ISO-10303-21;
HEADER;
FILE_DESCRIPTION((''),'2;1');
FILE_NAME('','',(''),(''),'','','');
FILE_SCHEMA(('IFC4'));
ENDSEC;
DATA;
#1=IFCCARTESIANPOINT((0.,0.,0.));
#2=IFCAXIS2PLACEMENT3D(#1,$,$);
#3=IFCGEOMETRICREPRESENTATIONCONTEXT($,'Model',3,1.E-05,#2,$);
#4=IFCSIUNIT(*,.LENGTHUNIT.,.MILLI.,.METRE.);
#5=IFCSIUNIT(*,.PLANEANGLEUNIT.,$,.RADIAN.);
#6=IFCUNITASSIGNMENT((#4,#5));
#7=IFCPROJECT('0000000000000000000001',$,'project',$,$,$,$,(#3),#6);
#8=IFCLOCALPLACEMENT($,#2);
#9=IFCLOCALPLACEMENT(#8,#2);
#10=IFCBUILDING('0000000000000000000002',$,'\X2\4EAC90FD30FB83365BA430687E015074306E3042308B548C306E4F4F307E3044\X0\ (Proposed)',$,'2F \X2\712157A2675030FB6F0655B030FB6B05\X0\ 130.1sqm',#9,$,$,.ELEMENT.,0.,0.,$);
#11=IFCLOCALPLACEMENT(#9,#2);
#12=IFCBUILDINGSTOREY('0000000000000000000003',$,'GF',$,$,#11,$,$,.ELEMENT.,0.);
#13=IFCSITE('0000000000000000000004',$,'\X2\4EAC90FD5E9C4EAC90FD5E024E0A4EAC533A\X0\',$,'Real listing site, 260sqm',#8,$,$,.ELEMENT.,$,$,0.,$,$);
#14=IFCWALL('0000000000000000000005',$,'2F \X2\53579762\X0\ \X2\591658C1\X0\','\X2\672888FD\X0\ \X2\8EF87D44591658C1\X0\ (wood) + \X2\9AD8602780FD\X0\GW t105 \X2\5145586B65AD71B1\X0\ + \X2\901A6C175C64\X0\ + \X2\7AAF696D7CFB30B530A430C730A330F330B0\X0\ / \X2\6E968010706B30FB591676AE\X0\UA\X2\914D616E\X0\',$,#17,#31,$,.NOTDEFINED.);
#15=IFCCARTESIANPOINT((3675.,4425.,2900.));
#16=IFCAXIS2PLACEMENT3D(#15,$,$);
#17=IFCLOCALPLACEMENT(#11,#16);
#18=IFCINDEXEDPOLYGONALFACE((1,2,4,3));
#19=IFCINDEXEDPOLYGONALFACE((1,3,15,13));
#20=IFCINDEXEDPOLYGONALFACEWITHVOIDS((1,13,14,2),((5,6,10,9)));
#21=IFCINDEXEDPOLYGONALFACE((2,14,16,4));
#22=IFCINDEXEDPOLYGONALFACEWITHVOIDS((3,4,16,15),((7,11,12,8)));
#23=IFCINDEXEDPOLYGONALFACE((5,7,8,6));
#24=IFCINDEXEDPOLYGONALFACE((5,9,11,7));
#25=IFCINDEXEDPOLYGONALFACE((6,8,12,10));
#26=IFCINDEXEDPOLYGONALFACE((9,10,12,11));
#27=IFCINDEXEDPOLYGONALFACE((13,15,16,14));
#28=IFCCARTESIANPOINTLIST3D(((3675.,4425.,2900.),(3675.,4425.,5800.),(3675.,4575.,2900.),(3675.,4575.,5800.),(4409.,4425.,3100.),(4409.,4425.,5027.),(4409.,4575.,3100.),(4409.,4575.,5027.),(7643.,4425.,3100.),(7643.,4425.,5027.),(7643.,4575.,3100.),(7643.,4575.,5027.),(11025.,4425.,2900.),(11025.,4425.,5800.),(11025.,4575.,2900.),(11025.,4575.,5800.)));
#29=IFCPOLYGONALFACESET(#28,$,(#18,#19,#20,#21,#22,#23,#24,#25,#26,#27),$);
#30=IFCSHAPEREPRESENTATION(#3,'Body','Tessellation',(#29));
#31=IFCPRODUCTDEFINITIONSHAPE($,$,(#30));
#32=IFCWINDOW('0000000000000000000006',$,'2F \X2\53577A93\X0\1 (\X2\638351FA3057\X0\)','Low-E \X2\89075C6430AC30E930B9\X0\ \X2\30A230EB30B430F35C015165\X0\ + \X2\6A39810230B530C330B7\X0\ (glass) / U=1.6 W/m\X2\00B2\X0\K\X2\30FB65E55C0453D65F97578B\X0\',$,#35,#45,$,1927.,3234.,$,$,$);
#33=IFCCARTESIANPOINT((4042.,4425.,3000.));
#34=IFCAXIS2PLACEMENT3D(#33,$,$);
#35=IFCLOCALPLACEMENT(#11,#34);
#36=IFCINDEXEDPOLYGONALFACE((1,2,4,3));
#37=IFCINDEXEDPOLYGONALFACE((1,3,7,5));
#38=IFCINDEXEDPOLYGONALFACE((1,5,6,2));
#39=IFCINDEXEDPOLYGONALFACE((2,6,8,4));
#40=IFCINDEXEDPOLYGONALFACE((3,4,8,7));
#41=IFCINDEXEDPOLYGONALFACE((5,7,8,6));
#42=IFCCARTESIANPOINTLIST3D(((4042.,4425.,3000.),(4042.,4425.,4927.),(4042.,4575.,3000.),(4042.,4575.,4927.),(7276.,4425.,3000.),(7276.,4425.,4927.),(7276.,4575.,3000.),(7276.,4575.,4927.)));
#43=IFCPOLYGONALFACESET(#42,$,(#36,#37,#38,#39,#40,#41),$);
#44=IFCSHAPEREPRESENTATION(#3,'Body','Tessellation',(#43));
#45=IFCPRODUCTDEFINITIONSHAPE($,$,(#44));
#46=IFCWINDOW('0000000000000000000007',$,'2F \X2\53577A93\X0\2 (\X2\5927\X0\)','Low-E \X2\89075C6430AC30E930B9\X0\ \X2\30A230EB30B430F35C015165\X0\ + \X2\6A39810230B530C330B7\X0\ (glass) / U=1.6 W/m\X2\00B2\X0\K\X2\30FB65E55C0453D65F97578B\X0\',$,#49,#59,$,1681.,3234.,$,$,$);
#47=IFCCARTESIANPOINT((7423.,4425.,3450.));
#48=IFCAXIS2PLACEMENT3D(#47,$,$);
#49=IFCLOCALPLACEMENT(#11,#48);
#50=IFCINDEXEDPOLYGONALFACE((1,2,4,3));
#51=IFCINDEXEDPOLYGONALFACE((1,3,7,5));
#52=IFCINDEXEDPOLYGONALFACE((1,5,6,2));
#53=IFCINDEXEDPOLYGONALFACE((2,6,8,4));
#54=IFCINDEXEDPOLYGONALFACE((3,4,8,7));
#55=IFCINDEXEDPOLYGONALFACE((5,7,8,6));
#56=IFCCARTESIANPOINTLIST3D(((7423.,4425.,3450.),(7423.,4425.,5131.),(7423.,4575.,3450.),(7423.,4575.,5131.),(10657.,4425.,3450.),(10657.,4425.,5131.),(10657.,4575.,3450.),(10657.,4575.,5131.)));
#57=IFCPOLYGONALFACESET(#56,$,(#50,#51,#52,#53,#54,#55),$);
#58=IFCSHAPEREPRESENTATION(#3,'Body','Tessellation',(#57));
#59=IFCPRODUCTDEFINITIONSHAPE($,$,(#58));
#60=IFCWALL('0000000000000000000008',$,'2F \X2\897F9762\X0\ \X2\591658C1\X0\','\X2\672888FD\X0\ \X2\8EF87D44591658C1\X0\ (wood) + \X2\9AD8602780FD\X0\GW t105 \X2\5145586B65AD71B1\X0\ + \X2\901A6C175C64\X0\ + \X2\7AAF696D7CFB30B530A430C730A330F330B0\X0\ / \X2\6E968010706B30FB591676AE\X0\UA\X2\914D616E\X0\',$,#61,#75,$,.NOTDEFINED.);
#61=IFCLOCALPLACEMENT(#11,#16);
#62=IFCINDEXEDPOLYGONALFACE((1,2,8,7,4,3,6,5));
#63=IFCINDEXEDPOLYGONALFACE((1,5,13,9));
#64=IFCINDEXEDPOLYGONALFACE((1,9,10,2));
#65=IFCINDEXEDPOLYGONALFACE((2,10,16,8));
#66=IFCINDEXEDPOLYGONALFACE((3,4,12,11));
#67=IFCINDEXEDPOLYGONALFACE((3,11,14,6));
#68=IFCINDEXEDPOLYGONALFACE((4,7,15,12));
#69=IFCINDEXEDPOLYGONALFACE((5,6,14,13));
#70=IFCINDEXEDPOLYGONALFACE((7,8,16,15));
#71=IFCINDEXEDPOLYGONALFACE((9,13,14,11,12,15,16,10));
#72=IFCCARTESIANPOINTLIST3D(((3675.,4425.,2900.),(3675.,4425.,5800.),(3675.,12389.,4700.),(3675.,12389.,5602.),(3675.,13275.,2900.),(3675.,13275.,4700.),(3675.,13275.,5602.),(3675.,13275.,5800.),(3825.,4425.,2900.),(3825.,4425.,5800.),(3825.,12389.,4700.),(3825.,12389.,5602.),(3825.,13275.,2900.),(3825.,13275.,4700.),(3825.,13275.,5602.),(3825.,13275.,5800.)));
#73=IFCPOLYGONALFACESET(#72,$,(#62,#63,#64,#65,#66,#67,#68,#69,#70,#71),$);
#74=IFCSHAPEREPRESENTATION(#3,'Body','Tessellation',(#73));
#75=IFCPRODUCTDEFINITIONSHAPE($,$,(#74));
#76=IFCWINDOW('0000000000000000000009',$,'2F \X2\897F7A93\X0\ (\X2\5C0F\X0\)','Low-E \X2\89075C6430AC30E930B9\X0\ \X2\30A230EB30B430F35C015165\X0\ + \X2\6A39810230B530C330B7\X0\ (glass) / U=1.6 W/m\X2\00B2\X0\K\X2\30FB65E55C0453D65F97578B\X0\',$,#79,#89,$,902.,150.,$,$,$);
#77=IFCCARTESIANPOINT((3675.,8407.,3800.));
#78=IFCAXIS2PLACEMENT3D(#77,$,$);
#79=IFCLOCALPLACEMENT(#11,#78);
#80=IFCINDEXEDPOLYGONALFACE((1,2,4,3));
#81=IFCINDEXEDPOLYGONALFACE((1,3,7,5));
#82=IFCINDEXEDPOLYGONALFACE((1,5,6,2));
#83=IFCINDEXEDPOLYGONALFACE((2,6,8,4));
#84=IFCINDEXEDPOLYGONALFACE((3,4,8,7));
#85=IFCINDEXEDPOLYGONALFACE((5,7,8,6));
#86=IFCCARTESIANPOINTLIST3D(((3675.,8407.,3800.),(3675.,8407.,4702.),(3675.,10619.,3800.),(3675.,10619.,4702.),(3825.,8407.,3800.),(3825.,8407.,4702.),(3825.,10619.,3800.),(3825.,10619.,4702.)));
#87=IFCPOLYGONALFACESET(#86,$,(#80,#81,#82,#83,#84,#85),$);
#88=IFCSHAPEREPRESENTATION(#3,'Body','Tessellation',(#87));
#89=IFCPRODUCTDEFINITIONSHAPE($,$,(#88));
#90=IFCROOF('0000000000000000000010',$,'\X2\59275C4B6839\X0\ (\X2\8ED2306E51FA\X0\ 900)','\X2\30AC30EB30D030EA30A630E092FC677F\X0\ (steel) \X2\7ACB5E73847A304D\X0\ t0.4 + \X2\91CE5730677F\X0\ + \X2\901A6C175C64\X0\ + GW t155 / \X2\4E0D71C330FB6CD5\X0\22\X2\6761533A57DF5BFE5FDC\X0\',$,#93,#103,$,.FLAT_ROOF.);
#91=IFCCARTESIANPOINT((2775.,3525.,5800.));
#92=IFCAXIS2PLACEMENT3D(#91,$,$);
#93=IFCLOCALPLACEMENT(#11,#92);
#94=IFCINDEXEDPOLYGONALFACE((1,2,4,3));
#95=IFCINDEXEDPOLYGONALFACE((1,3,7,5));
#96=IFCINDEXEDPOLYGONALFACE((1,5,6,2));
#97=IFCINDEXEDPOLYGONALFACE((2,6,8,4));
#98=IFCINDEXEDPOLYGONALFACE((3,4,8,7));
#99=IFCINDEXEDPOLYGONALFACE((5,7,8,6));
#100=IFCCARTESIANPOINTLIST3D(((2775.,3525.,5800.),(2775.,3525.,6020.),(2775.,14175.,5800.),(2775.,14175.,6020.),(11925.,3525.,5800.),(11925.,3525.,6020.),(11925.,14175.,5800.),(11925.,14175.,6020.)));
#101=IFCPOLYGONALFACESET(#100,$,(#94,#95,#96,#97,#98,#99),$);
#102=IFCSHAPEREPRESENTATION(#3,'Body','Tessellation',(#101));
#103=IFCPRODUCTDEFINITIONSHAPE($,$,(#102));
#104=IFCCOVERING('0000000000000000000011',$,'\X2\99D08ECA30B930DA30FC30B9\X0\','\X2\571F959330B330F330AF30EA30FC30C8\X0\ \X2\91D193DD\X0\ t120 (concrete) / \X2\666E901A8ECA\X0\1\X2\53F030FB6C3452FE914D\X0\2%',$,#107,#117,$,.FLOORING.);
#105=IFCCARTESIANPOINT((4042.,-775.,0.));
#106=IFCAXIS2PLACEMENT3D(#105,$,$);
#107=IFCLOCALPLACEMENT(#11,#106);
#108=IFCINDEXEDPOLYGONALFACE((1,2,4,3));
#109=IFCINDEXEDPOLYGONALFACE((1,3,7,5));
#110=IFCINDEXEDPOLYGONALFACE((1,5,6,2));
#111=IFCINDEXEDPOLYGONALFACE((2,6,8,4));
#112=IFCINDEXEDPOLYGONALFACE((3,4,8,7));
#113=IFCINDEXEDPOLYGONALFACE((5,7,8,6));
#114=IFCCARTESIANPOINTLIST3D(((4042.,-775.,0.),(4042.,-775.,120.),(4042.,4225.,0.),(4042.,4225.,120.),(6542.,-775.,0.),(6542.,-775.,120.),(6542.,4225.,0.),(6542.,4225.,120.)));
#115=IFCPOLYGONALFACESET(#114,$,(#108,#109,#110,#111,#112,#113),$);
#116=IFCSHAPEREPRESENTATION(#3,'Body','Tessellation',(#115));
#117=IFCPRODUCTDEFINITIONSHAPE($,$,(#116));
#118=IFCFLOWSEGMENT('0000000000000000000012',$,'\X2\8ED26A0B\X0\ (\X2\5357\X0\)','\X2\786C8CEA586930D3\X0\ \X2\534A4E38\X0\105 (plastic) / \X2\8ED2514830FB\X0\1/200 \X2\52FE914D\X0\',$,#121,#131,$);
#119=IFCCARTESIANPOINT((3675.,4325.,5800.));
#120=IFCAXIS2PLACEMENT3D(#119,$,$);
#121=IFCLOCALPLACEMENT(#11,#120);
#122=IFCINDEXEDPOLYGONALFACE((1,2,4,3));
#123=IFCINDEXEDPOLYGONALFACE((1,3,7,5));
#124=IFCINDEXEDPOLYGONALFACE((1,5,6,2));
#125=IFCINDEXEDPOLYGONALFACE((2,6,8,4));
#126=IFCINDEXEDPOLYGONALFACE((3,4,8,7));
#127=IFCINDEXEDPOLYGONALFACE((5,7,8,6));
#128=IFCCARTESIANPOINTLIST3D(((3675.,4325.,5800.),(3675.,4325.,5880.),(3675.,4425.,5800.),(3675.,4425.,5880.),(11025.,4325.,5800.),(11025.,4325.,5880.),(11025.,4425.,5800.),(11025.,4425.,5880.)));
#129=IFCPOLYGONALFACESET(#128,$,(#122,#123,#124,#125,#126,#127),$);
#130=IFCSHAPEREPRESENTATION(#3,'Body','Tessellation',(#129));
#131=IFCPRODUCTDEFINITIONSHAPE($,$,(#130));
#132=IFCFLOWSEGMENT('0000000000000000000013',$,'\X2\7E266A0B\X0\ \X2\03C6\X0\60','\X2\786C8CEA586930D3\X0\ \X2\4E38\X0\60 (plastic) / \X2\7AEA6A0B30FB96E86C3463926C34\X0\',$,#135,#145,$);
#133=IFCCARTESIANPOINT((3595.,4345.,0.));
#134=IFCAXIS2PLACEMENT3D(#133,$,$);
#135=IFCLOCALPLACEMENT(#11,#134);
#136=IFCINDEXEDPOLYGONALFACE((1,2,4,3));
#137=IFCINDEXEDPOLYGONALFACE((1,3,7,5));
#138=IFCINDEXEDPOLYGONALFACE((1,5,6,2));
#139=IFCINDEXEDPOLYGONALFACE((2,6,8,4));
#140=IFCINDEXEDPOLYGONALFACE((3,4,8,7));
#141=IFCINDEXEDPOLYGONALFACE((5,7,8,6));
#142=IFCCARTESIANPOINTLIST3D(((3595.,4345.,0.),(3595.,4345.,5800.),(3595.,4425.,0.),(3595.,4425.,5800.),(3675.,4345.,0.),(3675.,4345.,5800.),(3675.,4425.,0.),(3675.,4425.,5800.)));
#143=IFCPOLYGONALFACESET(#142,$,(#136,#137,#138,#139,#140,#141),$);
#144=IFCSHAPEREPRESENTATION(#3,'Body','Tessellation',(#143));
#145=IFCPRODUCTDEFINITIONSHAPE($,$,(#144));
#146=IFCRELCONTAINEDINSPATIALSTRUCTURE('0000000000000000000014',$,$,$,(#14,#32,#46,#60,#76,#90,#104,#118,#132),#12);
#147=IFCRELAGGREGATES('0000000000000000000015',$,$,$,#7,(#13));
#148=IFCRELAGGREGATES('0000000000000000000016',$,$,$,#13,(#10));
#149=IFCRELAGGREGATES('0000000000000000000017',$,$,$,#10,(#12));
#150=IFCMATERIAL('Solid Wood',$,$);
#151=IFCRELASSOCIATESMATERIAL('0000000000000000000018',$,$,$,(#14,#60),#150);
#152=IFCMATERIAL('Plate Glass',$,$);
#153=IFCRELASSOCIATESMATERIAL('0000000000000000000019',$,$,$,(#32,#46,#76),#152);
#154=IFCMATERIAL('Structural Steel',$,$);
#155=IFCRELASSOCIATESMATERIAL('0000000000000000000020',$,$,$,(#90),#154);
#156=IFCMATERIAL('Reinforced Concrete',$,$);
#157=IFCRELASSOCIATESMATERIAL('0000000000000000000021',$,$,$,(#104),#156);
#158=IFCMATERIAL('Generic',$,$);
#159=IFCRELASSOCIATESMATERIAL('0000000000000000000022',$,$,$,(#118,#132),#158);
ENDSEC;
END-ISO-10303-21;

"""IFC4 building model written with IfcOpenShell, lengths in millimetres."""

from ifc_helpers import new_model, si_unit, frame, frame_2d, origin, place, context, project, spatial, rectangle, extrude, material, element, fill, save


model = new_model("IFC4")

# Units and contexts
model_context = context("Model", 3, precision=1e-05, world=origin())
ifc_project = project(units=[si_unit("LENGTHUNIT", "METRE", prefix="MILLI"), si_unit("PLANEANGLEUNIT", "RADIAN")], contexts=[model_context])

# Site, building, storey
site_placement = place(None, origin())
site = spatial("IfcSite", under=ifc_project, at=site_placement, Name="京都府京都市上京区", ObjectType="Real listing site, 260sqm", CompositionType="ELEMENT", RefElevation=0.0)
building_placement = place(site_placement, origin())
building = spatial("IfcBuilding", under=site, at=building_placement, Name="京都・茶室と縁側のある和の住まい (Proposed)", ObjectType="2F 無垢材・漆喰・欅 130.1sqm", CompositionType="ELEMENT", ElevationOfRefHeight=0.0, ElevationOfTerrain=0.0)
storey_placement = place(building_placement, origin())
storey = spatial("IfcBuildingStorey", under=building, at=storey_placement, Name="GF", CompositionType="ELEMENT", Elevation=0.0)

# Shared definitions
ifc_material_1 = material(Name="Solid Wood")

# Shared definitions
ifc_material_2 = material(Name="Reinforced Concrete")

# Shared definitions
ifc_material_3 = material(Name="Plate Glass")

# Wall, openings, windows
wall_1_placement = place(storey_placement, frame((3675.0, 4425.0, 2900.0)))
wall_1 = element("IfcWall", 1, at=wall_1_placement, inside=storey, material=ifc_material_1, Name="2F 南面 外壁", Description="木製 軸組外壁 (wood) + 高性能GW t105 充填断熱 + 通気層 + 窯業系サイディング / 準耐火・外皮UA配慮", PredefinedType="NOTDEFINED", context=model_context, shape_type="SweptSolid", body=[
    extrude(rectangle(XDim=7350.0, YDim=150.0, at=frame_2d((3675.0, 75.0))), frame((3675.0, 4425.0, 2900.0)), (0.0, 0.0, 1.0), 2900.0),
])
opening_1_placement = place(storey_placement, frame((4042.0, 4425.0, 3000.0)))
opening_1 = element("IfcOpeningElement", 2, at=opening_1_placement, cuts=wall_1, PredefinedType="NOTDEFINED", context=model_context, shape_type="SweptSolid", body=[
    extrude(rectangle(XDim=3234.0, YDim=150.0, at=frame_2d((1617.0, 75.0))), frame((4042.0, 4425.0, 3000.0)), (0.0, 0.0, 1.0), 1927.0),
])
opening_2_placement = place(storey_placement, frame((7423.0, 4425.0, 3450.0)))
opening_2 = element("IfcOpeningElement", 3, at=opening_2_placement, cuts=wall_1, PredefinedType="NOTDEFINED", context=model_context, shape_type="SweptSolid", body=[
    extrude(rectangle(XDim=3234.0, YDim=150.0, at=frame_2d((1617.0, 75.0))), frame((7423.0, 4425.0, 3450.0)), (0.0, 0.0, 1.0), 1681.0),
])
window_1_placement = place(storey_placement, frame((4042.0, 4425.0, 3000.0)))
window_1 = element("IfcWindow", 4, at=window_1_placement, inside=storey, material=ifc_material_3, Name="2F 南窓1 (掃出し)", Description="Low-E 複層ガラス アルゴン封入 + 樹脂サッシ (glass) / U=1.6 W/m²K・日射取得型", OverallHeight=1927.0, OverallWidth=3234.0, context=model_context, shape_type="SweptSolid", body=[
    extrude(rectangle(XDim=3234.0, YDim=150.0, at=frame_2d((1617.0, 75.0))), frame((4042.0, 4425.0, 3000.0)), (0.0, 0.0, 1.0), 1927.0),
])
fill(opening_1, window_1)
window_2_placement = place(storey_placement, frame((7423.0, 4425.0, 3450.0)))
window_2 = element("IfcWindow", 5, at=window_2_placement, inside=storey, material=ifc_material_3, Name="2F 南窓2 (大)", Description="Low-E 複層ガラス アルゴン封入 + 樹脂サッシ (glass) / U=1.6 W/m²K・日射取得型", OverallHeight=1681.0, OverallWidth=3234.0, context=model_context, shape_type="SweptSolid", body=[
    extrude(rectangle(XDim=3234.0, YDim=150.0, at=frame_2d((1617.0, 75.0))), frame((7423.0, 4425.0, 3450.0)), (0.0, 0.0, 1.0), 1681.0),
])
fill(opening_2, window_2)

# Wall, opening, window
wall_2_placement = place(storey_placement, frame((3675.0, 4425.0, 2900.0)))
wall_2 = element("IfcWall", 6, at=wall_2_placement, inside=storey, material=ifc_material_1, Name="2F 西面 外壁", Description="木製 軸組外壁 (wood) + 高性能GW t105 充填断熱 + 通気層 + 窯業系サイディング / 準耐火・外皮UA配慮", PredefinedType="NOTDEFINED", context=model_context, shape_type="SweptSolid", body=[
    extrude(rectangle(XDim=150.0, YDim=8850.0, at=frame_2d((75.0, 4425.0))), frame((3675.0, 4425.0, 2900.0)), (0.0, 0.0, 1.0), 2900.0),
])
opening_3_placement = place(storey_placement, frame((3675.0, 8407.0, 3800.0)))
opening_3 = element("IfcOpeningElement", 7, at=opening_3_placement, cuts=wall_2, PredefinedType="NOTDEFINED", context=model_context, shape_type="SweptSolid", body=[
    extrude(rectangle(XDim=150.0, YDim=2212.0, at=frame_2d((75.0, 1106.0))), frame((3675.0, 8407.0, 3800.0)), (0.0, 0.0, 1.0), 902.0),
])
window_3_placement = place(storey_placement, frame((3675.0, 8407.0, 3800.0)))
window_3 = element("IfcWindow", 8, at=window_3_placement, inside=storey, material=ifc_material_3, Name="2F 西窓 (小)", Description="Low-E 複層ガラス アルゴン封入 + 樹脂サッシ (glass) / U=1.6 W/m²K・日射取得型", OverallHeight=902.0, OverallWidth=150.0, context=model_context, shape_type="SweptSolid", body=[
    extrude(rectangle(XDim=150.0, YDim=2212.0, at=frame_2d((75.0, 1106.0))), frame((3675.0, 8407.0, 3800.0)), (0.0, 0.0, 1.0), 902.0),
])
fill(opening_3, window_3)

# Roof
ifc_material_4 = material(Name="Structural Steel")
roof_placement = place(storey_placement, frame((2775.0, 3525.0, 5800.0)))
element("IfcRoof", 9, at=roof_placement, inside=storey, material=ifc_material_4, Name="大屋根 (軒の出 900)", Description="ガルバリウム鋼板 (steel) 立平葺き t0.4 + 野地板 + 通気層 + GW t155 / 不燃・法22条区域対応", PredefinedType="FLAT_ROOF", context=model_context, shape_type="SweptSolid", body=[
    extrude(rectangle(XDim=9150.0, YDim=10650.0, at=frame_2d((4575.0, 5325.0))), frame((2775.0, 3525.0, 5800.0)), (0.0, 0.0, 1.0), 220.0),
])

# Covering
covering_placement = place(storey_placement, frame((4042.0, -775.0, 0.0)))
element("IfcCovering", 10, at=covering_placement, inside=storey, material=ifc_material_2, Name="駐車スペース", Description="土間コンクリート 金鏝 t120 (concrete) / 普通車1台・水勾配2%", PredefinedType="FLOORING", context=model_context, shape_type="SweptSolid", body=[
    extrude(rectangle(XDim=2500.0, YDim=5000.0, at=frame_2d((1250.0, 2500.0))), frame((4042.0, -775.0, 0.0)), (0.0, 0.0, 1.0), 120.0),
])

# Flow segments
ifc_material_5 = material(Name="Generic")
flow_segment_1_placement = place(storey_placement, frame((3675.0, 4325.0, 5800.0)))
element("IfcFlowSegment", 11, at=flow_segment_1_placement, inside=storey, material=ifc_material_5, Name="軒樋 (南)", Description="硬質塩ビ 半丸105 (plastic) / 軒先・1/200 勾配", context=model_context, shape_type="SweptSolid", body=[
    extrude(rectangle(XDim=7350.0, YDim=100.0, at=frame_2d((3675.0, 50.0))), frame((3675.0, 4325.0, 5800.0)), (0.0, 0.0, 1.0), 80.0),
])
flow_segment_2_placement = place(storey_placement, frame((3595.0, 4345.0, 0.0)))
element("IfcFlowSegment", 12, at=flow_segment_2_placement, inside=storey, material=ifc_material_5, Name="縦樋 φ60", Description="硬質塩ビ 丸60 (plastic) / 竪樋・雨水排水", context=model_context, shape_type="SweptSolid", body=[
    extrude(rectangle(XDim=80.0, YDim=80.0, at=frame_2d((40.0, 40.0))), frame((3595.0, 4345.0, 0.0)), (0.0, 0.0, 1.0), 5800.0),
])

save(model, "model.ifc")
